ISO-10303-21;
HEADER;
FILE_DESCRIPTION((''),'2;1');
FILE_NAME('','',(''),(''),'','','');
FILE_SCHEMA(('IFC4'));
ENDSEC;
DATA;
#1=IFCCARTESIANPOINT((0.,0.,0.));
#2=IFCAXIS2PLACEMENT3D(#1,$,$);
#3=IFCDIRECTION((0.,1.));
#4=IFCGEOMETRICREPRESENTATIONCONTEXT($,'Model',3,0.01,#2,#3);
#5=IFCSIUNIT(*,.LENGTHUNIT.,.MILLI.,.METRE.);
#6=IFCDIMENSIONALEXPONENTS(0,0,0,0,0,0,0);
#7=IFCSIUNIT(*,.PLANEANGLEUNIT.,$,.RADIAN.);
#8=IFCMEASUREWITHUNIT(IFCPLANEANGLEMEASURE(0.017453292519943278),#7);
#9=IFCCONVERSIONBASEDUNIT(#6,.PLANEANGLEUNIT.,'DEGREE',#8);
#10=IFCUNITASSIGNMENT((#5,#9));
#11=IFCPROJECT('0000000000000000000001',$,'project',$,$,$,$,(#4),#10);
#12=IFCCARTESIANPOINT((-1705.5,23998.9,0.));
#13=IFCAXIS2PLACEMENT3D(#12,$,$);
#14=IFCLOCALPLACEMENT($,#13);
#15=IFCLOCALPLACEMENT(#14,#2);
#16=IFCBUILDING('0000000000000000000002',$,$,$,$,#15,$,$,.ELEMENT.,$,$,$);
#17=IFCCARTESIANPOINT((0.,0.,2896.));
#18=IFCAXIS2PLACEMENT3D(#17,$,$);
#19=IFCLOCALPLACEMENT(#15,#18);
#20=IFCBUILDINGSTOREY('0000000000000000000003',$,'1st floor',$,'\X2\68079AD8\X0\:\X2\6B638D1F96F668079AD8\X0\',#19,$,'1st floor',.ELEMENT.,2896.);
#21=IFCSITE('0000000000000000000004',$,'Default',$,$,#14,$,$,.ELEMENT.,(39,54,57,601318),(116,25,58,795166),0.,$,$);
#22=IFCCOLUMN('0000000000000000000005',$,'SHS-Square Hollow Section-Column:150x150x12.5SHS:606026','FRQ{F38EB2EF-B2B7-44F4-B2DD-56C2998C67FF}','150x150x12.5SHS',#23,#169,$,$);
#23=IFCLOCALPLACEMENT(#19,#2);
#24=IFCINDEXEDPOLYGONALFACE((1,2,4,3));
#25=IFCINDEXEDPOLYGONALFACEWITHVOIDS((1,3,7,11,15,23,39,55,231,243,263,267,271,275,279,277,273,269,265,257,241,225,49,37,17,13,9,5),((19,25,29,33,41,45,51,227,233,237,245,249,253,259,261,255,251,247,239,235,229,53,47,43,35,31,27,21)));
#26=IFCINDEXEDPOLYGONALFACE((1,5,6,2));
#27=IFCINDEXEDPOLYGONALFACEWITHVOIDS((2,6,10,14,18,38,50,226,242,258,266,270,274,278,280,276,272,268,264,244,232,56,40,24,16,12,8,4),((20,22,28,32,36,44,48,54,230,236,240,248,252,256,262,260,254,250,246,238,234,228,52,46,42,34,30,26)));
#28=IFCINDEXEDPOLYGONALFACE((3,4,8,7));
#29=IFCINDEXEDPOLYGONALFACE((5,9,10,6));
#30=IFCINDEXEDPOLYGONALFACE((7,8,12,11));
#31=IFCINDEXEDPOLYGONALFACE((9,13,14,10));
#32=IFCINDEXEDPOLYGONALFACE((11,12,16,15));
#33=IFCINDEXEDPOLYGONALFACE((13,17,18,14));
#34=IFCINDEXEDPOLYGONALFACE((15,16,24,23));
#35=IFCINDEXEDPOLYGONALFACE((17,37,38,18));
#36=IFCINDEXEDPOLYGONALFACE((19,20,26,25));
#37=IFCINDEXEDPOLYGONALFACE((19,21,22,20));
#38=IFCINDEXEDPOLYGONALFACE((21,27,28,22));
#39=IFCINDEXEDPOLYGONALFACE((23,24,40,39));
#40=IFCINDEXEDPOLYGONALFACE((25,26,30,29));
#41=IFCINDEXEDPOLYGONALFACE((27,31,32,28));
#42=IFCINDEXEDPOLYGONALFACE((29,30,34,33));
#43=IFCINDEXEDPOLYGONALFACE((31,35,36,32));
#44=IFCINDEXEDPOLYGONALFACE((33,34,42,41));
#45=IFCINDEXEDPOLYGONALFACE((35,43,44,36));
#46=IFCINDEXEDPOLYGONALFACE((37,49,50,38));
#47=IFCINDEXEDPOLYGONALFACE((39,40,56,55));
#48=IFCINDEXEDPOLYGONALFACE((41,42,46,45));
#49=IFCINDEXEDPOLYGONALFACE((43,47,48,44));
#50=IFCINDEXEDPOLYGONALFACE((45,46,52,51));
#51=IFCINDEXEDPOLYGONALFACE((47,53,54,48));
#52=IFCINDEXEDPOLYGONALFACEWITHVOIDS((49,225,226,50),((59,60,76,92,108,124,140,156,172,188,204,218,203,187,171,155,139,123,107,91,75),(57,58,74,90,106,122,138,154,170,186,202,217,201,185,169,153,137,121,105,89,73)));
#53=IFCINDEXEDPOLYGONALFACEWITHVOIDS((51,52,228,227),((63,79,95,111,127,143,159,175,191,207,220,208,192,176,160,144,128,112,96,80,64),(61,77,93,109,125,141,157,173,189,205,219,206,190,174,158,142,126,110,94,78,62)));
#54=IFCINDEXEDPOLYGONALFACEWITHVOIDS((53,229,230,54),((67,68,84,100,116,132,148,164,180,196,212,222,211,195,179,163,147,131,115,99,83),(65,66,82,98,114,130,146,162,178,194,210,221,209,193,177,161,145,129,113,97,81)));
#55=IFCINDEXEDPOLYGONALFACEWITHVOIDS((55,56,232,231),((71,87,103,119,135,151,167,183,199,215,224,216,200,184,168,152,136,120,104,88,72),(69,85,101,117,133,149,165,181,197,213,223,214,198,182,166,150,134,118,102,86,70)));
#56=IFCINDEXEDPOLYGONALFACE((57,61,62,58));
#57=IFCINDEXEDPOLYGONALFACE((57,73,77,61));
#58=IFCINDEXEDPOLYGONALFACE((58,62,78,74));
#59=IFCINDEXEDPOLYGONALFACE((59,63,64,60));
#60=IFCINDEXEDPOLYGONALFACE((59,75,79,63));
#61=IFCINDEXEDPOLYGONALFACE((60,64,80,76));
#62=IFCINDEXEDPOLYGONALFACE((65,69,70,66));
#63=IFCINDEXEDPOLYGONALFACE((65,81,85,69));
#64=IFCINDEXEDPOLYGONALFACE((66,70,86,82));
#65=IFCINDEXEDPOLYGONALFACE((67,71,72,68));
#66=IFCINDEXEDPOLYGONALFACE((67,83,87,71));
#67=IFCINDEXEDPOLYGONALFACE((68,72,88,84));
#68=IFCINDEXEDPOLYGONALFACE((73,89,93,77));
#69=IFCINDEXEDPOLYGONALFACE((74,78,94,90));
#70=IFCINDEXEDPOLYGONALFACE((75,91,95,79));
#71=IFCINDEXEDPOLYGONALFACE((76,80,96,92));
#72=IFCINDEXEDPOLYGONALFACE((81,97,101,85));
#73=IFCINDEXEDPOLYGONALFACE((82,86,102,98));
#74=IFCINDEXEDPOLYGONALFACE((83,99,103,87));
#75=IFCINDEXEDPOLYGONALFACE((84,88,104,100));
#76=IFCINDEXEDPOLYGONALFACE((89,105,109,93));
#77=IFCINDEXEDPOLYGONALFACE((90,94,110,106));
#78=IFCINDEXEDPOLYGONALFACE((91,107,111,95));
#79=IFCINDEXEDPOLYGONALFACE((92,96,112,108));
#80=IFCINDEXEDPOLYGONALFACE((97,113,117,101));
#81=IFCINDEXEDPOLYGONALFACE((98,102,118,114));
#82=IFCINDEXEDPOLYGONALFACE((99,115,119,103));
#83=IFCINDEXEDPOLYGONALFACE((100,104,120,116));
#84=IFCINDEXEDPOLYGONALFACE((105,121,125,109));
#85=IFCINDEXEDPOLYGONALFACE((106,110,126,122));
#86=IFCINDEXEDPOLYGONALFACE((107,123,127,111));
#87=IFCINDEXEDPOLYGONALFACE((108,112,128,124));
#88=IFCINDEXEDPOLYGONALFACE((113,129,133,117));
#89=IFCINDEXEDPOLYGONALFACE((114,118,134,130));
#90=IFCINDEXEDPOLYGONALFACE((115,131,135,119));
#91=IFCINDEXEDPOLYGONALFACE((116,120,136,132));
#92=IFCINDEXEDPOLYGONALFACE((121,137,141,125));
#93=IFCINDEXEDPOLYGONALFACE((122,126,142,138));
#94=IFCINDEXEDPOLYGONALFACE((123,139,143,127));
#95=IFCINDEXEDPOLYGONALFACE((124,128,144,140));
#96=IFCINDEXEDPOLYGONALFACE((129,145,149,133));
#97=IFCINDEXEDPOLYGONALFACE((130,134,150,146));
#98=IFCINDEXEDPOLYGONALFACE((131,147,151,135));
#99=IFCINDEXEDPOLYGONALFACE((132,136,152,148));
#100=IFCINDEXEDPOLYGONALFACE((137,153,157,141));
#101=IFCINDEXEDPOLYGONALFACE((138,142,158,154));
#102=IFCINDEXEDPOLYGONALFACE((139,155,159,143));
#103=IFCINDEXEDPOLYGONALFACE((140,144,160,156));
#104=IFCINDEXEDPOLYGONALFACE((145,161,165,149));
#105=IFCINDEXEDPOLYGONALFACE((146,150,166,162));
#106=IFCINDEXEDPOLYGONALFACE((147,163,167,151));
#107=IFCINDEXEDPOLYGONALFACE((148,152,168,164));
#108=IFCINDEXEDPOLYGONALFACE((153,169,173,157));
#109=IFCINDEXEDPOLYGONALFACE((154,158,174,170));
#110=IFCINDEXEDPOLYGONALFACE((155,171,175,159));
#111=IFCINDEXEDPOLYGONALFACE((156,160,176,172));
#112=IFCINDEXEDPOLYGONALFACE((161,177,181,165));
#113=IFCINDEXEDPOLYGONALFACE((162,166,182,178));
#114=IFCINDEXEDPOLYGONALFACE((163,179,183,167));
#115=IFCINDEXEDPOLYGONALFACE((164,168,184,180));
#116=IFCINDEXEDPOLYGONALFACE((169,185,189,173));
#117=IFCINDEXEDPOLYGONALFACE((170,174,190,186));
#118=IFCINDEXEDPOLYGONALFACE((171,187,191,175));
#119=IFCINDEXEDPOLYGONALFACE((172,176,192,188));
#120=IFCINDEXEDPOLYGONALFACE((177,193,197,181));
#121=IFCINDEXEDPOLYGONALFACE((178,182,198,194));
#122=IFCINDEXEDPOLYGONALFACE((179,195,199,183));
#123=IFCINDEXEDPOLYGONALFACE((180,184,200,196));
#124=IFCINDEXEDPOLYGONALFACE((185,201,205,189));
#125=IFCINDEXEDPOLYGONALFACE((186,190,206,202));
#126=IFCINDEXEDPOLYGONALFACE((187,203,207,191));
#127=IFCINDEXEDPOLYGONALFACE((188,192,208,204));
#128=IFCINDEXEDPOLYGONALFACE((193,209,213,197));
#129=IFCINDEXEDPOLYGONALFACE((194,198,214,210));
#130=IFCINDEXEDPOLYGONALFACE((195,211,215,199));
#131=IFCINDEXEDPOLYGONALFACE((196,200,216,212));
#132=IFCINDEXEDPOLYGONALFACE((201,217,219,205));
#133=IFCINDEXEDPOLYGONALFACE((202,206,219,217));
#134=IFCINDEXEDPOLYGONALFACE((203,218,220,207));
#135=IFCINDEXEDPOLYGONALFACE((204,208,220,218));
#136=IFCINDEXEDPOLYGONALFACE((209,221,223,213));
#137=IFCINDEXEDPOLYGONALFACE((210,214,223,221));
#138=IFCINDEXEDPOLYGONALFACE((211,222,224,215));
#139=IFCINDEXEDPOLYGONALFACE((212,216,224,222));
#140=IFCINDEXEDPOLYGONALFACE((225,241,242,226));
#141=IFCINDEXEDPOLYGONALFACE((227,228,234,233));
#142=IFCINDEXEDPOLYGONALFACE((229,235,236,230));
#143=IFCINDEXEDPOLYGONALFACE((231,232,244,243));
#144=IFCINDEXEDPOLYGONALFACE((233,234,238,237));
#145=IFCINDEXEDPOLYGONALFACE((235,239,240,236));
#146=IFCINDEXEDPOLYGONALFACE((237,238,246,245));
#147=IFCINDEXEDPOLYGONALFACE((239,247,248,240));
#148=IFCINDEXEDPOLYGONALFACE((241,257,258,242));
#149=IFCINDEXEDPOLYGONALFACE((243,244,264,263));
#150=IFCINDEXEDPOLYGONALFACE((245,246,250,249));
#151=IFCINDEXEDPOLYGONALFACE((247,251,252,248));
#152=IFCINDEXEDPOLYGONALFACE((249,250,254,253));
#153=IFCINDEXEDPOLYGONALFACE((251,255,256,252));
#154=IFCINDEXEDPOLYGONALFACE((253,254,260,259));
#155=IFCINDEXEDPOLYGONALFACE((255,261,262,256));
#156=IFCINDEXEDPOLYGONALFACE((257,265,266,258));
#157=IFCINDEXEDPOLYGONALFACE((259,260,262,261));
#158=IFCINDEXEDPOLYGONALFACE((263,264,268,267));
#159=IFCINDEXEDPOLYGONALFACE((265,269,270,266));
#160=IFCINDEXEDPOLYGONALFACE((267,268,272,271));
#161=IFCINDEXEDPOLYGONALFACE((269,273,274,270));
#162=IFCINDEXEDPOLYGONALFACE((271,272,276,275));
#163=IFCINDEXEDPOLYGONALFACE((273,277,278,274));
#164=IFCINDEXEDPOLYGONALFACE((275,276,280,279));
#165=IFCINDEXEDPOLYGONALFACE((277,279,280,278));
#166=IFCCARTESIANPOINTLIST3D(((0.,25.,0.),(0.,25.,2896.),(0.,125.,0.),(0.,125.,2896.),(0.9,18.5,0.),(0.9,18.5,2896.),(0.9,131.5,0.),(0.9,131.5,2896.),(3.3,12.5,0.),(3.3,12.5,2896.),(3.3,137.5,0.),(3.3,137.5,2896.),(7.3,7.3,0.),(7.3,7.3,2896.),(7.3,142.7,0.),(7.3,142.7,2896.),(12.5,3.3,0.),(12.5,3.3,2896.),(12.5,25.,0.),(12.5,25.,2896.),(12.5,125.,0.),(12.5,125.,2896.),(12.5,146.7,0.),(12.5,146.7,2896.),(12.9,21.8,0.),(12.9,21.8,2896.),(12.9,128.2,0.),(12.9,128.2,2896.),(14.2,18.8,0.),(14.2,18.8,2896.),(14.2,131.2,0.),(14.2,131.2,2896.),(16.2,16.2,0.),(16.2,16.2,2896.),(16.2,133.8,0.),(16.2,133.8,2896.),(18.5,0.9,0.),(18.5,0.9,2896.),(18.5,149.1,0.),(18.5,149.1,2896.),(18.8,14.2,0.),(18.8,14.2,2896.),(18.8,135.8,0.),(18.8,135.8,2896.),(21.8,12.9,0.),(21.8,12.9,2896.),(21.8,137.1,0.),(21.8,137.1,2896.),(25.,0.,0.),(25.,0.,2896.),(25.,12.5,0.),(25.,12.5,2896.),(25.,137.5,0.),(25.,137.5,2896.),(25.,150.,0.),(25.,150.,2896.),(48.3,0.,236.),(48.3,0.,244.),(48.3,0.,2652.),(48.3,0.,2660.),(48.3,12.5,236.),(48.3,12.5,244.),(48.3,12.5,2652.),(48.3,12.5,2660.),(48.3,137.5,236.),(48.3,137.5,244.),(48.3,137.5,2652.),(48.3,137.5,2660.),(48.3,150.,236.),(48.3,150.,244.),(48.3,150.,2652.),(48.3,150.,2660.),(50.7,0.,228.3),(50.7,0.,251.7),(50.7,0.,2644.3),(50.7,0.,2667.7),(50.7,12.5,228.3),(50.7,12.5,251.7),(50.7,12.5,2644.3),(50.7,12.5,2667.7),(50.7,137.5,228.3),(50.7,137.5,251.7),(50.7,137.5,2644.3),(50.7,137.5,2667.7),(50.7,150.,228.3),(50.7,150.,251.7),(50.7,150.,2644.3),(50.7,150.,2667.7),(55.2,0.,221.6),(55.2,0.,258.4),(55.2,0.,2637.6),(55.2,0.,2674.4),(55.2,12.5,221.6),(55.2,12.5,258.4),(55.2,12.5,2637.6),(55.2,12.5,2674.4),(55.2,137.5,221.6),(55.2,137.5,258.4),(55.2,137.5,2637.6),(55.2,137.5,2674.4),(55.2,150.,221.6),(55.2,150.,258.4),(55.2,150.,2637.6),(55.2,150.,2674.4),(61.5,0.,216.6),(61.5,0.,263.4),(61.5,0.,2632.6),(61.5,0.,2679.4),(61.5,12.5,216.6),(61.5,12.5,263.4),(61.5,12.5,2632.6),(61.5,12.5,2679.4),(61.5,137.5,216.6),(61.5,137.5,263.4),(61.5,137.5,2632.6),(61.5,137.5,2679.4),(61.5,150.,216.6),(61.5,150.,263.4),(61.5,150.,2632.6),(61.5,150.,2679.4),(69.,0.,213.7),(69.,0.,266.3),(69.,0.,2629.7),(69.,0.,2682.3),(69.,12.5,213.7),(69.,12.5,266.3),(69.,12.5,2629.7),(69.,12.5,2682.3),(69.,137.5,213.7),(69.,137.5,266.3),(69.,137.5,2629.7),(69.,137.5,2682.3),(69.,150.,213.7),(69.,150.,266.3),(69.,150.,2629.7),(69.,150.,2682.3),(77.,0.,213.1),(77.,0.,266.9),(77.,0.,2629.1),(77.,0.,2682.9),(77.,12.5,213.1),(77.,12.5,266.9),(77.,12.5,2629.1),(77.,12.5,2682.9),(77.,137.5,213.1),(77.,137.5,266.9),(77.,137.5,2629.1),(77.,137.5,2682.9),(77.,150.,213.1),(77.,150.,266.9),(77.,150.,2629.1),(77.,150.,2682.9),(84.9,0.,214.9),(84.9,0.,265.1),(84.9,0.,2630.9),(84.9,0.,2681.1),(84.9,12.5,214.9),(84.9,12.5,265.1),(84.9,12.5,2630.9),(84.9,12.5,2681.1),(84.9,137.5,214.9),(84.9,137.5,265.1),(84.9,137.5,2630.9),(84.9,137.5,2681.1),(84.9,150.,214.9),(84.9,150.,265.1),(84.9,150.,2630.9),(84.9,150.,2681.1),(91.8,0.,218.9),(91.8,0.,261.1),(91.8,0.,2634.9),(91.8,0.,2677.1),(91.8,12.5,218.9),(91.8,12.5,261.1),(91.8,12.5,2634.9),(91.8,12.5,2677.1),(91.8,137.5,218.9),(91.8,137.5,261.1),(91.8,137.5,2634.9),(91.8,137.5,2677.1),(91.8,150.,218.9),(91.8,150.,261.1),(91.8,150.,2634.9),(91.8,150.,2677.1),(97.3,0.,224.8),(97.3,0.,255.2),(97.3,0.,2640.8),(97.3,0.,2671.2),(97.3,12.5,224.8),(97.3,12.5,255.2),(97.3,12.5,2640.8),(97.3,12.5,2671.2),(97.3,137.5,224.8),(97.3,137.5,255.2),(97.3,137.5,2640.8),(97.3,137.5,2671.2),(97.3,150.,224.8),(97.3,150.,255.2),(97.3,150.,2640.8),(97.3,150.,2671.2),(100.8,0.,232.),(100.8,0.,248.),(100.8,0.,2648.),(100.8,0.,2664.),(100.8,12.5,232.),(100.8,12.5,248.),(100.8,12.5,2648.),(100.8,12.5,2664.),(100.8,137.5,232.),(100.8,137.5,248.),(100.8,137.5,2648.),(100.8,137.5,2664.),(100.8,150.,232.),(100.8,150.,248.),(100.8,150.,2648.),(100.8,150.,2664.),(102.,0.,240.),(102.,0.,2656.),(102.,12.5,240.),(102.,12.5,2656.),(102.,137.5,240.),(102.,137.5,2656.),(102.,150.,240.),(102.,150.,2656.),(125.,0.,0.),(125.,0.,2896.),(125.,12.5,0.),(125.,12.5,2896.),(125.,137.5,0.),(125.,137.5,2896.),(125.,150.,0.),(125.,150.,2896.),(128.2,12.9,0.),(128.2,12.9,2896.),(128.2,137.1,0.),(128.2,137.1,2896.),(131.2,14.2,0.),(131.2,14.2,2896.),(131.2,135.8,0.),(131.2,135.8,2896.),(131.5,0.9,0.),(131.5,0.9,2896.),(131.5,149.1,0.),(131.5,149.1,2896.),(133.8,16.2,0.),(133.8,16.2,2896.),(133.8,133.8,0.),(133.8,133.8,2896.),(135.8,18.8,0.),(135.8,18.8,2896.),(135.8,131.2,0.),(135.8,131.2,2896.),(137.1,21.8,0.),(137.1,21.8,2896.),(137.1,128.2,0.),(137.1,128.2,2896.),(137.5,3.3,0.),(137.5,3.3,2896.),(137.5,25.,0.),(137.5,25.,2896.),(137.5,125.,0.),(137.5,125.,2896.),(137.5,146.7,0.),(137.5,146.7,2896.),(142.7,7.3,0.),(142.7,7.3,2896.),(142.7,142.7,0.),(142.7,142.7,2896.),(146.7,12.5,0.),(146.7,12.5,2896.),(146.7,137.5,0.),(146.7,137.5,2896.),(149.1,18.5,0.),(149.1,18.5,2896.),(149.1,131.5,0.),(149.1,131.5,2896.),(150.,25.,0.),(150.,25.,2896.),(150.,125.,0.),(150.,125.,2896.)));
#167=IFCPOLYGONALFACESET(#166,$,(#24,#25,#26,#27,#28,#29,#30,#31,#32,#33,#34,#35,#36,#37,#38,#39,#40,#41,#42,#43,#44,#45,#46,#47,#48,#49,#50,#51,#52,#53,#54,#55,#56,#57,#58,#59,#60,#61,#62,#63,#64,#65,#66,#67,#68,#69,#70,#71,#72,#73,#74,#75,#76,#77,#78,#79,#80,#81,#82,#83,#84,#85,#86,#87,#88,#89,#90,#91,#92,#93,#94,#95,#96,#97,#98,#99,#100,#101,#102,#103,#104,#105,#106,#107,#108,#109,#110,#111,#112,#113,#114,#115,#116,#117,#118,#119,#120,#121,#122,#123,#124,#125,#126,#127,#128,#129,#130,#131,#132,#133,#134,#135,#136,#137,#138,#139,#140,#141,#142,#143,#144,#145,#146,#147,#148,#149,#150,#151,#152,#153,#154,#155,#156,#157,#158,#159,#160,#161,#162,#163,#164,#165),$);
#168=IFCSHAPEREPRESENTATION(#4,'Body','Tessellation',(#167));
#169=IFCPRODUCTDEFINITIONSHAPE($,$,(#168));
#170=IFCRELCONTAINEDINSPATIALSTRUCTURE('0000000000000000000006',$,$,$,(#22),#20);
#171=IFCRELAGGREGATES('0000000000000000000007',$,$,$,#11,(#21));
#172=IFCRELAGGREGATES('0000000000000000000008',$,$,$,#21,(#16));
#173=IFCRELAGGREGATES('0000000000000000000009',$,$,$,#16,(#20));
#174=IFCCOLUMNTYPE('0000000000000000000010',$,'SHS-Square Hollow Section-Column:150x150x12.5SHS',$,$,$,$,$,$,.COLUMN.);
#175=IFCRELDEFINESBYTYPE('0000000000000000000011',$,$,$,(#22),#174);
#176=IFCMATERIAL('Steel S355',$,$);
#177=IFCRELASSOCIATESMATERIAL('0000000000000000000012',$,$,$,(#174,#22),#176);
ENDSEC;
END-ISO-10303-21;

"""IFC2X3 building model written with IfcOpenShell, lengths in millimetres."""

from ifc_helpers import new_model, entity, si_unit, converted_unit, direction, frame, frame_2d, origin, origin_2d, place, context, project, spatial, circle_curve, hollow_rectangle, outline, extrude, material, type_object, element, save


model = new_model("IFC2X3")

# Units and contexts
model_context = context("Model", 3, precision=0.01, world=origin(), true_north=direction((0.0, 1.0)))
ifc_project = project(units=[si_unit("LENGTHUNIT", "METRE", prefix="MILLI"), converted_unit("PLANEANGLEUNIT", "DEGREE", entity("IfcPlaneAngleMeasure", 0.017453292519943278), si_unit("PLANEANGLEUNIT", "RADIAN"), dimensions=[0, 0, 0, 0, 0, 0, 0])], contexts=[model_context])

# Site, building, storey
site_placement = place(None, frame((-1705.5, 23998.9, 0.0)))
site = spatial("IfcSite", under=ifc_project, at=site_placement, Name="Default", CompositionType="ELEMENT", RefLatitude=(39, 54, 57, 601318), RefLongitude=(116, 25, 58, 795166), RefElevation=0.0)
building_placement = place(site_placement, origin())
building = spatial("IfcBuilding", under=site, at=building_placement, CompositionType="ELEMENT")
storey_placement = place(building_placement, frame((0.0, 0.0, 2896.0)))
storey = spatial("IfcBuildingStorey", under=building, at=storey_placement, Name="1st floor", ObjectType="标高:正负零标高", LongName="1st floor", CompositionType="ELEMENT", Elevation=2896.0)

# Column, openings
ifc_material_1 = material(Name="Steel S355")
column_type_1 = type_object("IfcColumnType", Name="SHS-Square Hollow Section-Column:150x150x12.5SHS", PredefinedType="COLUMN", material=ifc_material_1)
column_1_placement = place(storey_placement, frame((75.0, 75.0, 2896.0), z_axis=(0.0, 0.0, 1.0), x_axis=(0.0, -1.0, 0.0)))
column_1 = element("IfcColumn", 1, at=column_1_placement, inside=storey, type_object=column_type_1, material=ifc_material_1, Name="SHS-Square Hollow Section-Column:150x150x12.5SHS:606026", Description="FRQ{F38EB2EF-B2B7-44F4-B2DD-56C2998C67FF}", ObjectType="150x150x12.5SHS", context=model_context, shape_type="SweptSolid", body=[
    extrude(hollow_rectangle(XDim=150.0, YDim=150.0, WallThickness=12.5, InnerFilletRadius=12.5, OuterFilletRadius=25.0, at=origin_2d()), origin(), (0.0, 0.0, -1.0), 2896.0),
])
opening_1_placement = place(column_1_placement, frame((-175.1, 0.0, -2896.0), z_axis=(1.0, 0.0, 0.0), x_axis=(0.0, 1.0, 0.0)))
element("IfcOpeningElement", 2, at=opening_1_placement, cuts=column_1, ObjectType="Opening", context=model_context, shape_type="SweptSolid", body=[
    extrude(outline(circle_curve(frame_2d((0.0, 240.0), x_axis=(1.0, 0.0)), 27.0)), origin(), (0.0, 0.0, 1.0), 350.2),
])
opening_2_placement = place(column_1_placement, frame((-175.1, 0.0, 0.0), z_axis=(1.0, 0.0, 0.0), x_axis=(0.0, 1.0, 0.0)))
element("IfcOpeningElement", 3, at=opening_2_placement, cuts=column_1, ObjectType="Opening", context=model_context, shape_type="SweptSolid", body=[
    extrude(outline(circle_curve(frame_2d((0.0, -240.0), x_axis=(1.0, 0.0)), 27.0)), origin(), (0.0, 0.0, 1.0), 350.2),
])

save(model, "model.ifc")
